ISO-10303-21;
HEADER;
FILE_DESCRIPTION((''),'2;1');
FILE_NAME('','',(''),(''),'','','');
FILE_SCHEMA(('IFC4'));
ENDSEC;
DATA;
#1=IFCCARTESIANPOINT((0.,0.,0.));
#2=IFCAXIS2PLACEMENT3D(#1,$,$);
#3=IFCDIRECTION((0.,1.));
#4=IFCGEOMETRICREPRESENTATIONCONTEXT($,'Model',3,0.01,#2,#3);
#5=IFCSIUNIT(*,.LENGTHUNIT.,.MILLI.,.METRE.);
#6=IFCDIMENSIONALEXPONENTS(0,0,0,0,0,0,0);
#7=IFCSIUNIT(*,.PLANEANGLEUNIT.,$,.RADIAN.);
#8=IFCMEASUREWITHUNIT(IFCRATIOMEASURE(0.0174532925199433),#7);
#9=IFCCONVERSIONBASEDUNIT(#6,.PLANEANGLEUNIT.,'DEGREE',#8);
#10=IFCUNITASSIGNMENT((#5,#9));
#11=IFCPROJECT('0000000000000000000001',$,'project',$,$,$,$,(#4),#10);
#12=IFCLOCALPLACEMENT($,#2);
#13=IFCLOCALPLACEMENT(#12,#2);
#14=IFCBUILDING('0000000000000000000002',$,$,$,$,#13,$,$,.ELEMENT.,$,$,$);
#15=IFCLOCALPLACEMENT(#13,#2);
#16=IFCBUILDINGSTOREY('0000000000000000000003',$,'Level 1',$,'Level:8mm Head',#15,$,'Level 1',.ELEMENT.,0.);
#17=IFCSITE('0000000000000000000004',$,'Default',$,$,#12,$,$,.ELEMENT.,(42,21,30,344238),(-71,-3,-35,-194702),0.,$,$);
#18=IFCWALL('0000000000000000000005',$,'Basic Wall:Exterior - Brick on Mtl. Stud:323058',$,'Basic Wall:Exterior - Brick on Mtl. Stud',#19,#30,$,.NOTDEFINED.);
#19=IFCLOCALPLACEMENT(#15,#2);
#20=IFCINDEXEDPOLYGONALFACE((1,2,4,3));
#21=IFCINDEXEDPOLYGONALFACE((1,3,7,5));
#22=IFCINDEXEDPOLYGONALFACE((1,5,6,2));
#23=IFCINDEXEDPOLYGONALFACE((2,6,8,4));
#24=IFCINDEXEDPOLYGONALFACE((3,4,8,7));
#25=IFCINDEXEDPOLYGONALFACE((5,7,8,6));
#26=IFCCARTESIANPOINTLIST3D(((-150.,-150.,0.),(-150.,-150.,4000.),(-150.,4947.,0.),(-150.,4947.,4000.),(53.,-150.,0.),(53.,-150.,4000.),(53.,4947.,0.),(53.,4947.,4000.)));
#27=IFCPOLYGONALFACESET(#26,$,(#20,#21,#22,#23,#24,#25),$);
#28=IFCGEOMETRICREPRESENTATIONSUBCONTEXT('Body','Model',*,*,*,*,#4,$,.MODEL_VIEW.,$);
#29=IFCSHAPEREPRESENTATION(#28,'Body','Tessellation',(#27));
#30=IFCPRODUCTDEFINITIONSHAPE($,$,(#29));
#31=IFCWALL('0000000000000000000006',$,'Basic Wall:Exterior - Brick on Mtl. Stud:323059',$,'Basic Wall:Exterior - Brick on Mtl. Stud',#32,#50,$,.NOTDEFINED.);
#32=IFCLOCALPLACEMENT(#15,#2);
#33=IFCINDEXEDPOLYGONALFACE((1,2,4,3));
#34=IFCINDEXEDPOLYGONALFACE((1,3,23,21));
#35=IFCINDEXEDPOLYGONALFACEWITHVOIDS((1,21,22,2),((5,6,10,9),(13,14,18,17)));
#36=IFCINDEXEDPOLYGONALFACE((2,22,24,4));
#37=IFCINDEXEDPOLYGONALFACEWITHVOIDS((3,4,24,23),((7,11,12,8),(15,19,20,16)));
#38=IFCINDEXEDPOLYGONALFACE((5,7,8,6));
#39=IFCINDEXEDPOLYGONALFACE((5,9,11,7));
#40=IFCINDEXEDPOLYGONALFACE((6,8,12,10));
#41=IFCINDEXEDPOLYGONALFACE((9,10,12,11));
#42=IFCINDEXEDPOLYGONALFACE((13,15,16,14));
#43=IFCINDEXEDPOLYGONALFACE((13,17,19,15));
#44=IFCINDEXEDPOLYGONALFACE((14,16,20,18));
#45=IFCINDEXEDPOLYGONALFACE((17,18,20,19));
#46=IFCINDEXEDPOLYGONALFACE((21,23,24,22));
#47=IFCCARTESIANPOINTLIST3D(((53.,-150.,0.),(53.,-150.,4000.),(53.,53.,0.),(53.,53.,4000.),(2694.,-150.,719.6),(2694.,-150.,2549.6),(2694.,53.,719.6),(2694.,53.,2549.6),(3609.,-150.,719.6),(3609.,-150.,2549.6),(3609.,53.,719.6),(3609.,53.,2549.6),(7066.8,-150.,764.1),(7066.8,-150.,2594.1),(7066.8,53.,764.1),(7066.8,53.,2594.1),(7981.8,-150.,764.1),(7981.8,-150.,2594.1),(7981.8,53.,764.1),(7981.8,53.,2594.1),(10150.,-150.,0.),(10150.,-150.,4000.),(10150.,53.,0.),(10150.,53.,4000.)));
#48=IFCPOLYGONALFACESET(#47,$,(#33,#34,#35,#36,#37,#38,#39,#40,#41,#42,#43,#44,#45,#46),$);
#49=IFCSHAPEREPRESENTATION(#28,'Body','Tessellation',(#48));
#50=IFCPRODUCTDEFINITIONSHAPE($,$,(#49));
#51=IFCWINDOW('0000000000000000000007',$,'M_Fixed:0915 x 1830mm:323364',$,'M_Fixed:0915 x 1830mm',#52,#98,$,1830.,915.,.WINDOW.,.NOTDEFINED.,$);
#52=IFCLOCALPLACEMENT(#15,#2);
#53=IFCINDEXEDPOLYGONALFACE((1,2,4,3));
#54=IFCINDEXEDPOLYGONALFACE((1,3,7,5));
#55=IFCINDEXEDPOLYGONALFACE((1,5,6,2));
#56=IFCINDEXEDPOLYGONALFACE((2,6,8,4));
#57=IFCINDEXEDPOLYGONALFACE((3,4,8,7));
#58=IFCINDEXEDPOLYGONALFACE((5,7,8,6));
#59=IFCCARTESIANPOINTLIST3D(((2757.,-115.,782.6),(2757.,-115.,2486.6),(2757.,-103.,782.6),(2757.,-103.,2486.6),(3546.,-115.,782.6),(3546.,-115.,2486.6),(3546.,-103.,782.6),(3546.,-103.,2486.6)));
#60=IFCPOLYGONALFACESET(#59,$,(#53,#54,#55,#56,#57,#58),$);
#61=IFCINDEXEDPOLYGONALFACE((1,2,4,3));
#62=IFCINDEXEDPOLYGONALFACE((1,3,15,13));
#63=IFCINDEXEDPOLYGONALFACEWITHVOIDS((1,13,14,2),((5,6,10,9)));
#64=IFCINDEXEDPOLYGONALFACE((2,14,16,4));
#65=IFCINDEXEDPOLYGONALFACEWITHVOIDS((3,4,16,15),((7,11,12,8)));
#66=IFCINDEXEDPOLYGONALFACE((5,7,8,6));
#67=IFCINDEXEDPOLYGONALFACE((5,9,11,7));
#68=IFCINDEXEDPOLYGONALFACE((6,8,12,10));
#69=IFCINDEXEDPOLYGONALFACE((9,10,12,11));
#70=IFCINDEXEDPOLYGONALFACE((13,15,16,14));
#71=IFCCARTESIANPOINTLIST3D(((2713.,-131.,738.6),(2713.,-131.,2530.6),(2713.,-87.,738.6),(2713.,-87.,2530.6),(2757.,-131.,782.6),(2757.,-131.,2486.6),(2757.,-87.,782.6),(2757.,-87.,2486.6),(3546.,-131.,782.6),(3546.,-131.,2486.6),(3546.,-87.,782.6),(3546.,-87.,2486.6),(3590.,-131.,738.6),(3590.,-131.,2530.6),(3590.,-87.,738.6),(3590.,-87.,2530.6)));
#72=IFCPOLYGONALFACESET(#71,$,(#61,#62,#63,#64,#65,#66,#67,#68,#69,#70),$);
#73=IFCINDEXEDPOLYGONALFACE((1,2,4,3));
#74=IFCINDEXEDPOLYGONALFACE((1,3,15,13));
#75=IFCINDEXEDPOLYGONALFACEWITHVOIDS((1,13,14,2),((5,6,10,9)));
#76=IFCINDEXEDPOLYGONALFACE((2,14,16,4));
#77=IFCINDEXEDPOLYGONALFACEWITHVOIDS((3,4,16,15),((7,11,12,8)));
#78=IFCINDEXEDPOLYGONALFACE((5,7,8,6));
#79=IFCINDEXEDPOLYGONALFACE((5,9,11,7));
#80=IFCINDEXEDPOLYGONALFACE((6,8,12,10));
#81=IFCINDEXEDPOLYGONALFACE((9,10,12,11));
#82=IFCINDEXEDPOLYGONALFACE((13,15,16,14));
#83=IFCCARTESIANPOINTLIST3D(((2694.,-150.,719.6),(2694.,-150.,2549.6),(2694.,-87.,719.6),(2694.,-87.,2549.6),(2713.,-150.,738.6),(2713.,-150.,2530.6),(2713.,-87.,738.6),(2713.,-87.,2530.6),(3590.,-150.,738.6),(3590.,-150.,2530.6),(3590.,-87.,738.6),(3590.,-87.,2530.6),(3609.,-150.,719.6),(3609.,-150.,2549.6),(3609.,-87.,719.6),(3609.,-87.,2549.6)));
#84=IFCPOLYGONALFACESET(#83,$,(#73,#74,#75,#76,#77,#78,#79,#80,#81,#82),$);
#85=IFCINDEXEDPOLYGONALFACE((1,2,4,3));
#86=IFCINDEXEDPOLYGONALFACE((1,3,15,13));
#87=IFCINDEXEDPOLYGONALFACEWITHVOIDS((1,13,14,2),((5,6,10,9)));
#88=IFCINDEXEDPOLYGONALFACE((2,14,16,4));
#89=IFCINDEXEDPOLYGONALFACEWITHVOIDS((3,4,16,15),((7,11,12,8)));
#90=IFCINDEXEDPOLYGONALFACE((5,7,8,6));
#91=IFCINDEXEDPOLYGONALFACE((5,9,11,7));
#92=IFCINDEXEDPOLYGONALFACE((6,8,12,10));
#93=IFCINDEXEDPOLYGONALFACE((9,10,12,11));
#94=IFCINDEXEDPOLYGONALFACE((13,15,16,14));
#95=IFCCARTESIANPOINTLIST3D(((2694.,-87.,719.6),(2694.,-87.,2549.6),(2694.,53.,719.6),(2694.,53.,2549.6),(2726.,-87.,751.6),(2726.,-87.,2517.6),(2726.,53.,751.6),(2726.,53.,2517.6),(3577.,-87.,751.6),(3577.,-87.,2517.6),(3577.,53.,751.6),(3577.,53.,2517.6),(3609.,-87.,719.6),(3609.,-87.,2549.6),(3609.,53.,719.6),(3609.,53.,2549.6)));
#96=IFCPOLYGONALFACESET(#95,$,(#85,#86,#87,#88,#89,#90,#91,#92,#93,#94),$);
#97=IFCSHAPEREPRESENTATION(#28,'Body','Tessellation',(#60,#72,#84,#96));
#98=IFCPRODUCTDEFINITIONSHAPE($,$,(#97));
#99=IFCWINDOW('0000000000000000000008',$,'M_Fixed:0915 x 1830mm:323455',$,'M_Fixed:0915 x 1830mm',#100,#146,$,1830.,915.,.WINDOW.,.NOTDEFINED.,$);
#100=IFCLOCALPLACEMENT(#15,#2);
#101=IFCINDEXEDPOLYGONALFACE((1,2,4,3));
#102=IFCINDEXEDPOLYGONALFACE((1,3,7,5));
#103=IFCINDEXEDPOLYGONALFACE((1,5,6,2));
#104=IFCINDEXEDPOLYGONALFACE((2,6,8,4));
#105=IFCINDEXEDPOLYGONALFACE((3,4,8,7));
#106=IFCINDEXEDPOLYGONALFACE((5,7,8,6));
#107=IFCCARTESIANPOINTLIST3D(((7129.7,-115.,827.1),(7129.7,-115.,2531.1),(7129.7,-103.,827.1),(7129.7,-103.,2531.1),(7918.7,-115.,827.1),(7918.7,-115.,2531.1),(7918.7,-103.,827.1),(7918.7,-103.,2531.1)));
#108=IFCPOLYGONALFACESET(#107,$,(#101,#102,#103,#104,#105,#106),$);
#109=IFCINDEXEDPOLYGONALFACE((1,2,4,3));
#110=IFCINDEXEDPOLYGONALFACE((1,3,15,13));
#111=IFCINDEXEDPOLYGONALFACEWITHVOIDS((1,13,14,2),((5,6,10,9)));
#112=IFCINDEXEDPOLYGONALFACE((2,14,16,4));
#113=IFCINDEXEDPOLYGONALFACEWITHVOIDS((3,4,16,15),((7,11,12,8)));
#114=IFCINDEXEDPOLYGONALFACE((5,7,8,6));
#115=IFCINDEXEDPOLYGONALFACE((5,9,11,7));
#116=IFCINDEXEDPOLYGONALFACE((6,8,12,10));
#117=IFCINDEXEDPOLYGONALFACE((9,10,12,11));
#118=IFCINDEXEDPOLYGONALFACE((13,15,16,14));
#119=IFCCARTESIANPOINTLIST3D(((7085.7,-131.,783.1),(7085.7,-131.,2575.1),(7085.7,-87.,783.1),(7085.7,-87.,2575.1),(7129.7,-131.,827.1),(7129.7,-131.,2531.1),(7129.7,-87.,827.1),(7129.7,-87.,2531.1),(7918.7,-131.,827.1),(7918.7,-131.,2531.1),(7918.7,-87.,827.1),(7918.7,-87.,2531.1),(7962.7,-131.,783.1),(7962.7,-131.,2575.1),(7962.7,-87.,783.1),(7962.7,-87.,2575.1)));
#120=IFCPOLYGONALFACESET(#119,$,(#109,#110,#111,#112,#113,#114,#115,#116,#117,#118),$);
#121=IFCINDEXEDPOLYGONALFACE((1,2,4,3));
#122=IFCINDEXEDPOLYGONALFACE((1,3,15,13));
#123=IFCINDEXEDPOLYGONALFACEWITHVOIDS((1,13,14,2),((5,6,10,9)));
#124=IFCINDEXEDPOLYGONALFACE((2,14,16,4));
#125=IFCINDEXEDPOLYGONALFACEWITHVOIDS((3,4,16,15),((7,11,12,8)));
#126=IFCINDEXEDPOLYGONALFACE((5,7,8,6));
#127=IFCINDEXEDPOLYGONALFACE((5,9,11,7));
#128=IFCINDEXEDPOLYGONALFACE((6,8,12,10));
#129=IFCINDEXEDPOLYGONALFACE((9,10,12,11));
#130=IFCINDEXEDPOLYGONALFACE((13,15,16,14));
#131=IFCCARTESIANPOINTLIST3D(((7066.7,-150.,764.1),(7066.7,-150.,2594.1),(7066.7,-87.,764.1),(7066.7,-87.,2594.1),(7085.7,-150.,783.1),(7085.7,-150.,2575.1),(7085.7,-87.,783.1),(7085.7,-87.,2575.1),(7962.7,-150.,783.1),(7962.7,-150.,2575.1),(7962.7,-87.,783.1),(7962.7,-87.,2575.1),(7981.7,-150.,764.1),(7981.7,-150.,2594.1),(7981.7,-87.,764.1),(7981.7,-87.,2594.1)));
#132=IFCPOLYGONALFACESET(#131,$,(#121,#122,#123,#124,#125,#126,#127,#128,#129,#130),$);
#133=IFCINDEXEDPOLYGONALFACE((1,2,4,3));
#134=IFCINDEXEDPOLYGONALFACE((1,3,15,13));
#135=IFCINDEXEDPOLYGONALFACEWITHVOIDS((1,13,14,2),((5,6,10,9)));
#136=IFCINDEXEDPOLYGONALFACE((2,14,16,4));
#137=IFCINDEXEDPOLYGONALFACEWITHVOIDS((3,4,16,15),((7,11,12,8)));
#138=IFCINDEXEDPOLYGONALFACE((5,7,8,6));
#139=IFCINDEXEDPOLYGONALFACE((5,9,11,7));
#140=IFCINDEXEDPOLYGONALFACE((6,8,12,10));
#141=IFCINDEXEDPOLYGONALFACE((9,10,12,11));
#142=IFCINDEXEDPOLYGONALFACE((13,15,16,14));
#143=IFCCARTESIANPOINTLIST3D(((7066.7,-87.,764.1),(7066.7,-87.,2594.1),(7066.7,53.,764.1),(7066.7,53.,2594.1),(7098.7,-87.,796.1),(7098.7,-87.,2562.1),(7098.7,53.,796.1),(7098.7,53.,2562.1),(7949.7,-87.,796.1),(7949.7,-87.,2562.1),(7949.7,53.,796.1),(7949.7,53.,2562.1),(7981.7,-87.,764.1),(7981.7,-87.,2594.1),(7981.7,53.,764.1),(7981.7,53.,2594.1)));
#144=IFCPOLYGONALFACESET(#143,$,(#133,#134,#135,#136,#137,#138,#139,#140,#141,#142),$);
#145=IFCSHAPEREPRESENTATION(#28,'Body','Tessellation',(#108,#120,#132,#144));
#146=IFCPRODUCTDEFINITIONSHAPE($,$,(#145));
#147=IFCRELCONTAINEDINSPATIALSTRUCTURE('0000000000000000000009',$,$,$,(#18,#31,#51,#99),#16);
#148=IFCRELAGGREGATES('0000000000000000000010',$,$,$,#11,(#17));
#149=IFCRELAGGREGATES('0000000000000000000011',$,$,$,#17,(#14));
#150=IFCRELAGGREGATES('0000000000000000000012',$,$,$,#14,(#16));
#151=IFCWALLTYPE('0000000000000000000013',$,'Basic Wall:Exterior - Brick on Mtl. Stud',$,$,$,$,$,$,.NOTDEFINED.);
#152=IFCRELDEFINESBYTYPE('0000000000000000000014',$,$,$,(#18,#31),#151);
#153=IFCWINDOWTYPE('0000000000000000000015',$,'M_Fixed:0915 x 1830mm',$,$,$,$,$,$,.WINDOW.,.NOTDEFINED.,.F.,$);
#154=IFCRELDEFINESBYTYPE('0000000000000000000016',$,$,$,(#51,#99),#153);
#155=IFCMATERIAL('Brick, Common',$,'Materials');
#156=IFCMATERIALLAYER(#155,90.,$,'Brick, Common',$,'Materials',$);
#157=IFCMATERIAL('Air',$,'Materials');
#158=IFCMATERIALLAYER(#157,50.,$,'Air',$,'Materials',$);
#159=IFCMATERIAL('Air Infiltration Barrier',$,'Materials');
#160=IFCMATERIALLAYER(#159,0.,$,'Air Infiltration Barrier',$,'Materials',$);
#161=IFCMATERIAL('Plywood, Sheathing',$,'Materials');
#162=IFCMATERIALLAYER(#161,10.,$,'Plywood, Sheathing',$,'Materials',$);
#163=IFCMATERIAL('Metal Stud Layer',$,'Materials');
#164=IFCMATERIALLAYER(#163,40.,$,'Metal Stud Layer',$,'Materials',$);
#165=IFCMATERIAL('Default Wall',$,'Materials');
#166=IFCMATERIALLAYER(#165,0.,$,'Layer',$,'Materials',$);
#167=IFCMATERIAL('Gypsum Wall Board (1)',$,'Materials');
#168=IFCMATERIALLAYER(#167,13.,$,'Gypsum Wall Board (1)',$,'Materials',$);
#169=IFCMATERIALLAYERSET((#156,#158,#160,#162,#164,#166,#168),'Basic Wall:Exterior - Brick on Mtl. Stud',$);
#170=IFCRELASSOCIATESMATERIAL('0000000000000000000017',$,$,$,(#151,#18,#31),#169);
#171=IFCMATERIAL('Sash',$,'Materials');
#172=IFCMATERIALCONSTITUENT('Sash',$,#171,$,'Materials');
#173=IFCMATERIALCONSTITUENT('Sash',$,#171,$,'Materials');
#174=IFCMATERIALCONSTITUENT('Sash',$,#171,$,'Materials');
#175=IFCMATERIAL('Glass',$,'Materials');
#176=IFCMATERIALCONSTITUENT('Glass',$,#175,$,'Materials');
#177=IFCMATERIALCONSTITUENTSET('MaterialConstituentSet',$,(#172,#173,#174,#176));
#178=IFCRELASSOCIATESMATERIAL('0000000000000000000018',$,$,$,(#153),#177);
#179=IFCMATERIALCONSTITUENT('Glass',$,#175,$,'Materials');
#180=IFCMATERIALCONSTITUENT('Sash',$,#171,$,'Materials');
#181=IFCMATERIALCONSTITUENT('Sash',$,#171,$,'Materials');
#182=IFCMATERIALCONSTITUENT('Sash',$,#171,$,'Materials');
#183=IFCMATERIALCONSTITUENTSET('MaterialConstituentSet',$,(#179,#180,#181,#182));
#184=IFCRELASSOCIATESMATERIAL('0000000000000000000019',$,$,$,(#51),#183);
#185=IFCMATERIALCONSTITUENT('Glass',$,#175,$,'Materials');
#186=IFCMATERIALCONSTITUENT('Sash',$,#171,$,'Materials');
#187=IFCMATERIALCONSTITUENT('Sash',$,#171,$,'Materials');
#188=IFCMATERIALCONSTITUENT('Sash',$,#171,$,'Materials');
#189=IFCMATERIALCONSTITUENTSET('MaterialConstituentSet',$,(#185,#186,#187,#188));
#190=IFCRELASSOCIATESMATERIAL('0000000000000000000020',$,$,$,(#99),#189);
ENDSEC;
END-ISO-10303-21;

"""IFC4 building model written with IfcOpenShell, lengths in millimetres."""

from ifc_helpers import new_model, entity, si_unit, converted_unit, direction, frame, frame_2d, origin, place, context, subcontext, project, spatial, polyline, rectangle, outline, extrude, source, transform, mapped, material, layer, layer_set, layer_usage, constituent, constituent_set, type_object, type_shapes, element, fill, save


model = new_model("IFC4")

# Units and contexts
model_context = context("Model", 3, precision=0.01, world=origin(), true_north=direction((0.0, 1.0)))
body_context = subcontext(model_context, "Body", "Model", "MODEL_VIEW")
ifc_project = project(units=[si_unit("LENGTHUNIT", "METRE", prefix="MILLI"), converted_unit("PLANEANGLEUNIT", "DEGREE", entity("IfcRatioMeasure", 0.0174532925199433), si_unit("PLANEANGLEUNIT", "RADIAN"), dimensions=[0, 0, 0, 0, 0, 0, 0])], contexts=[model_context])

# Site, building, storey
site_placement = place(None, origin())
site = spatial("IfcSite", under=ifc_project, at=site_placement, Name="Default", CompositionType="ELEMENT", RefLatitude=(42, 21, 30, 344238), RefLongitude=(-71, -3, -35, -194702), RefElevation=0.0)
building_placement = place(site_placement, origin())
building = spatial("IfcBuilding", under=site, at=building_placement, CompositionType="ELEMENT")
storey_placement = place(building_placement, origin())
storey = spatial("IfcBuildingStorey", under=building, at=storey_placement, Name="Level 1", ObjectType="Level:8mm Head", LongName="Level 1", CompositionType="ELEMENT", Elevation=0.0)

# Shared definitions
ifc_material_1 = material(Name="Brick, Common", Category="Materials")
ifc_layer_1 = layer(ifc_material_1, 90.0, Name="Brick, Common", Category="Materials")
ifc_material_2 = material(Name="Air", Category="Materials")
ifc_layer_2 = layer(ifc_material_2, 50.0, Name="Air", Category="Materials")
ifc_material_3 = material(Name="Air Infiltration Barrier", Category="Materials")
ifc_layer_3 = layer(ifc_material_3, 0.0, Name="Air Infiltration Barrier", Category="Materials")
ifc_material_4 = material(Name="Plywood, Sheathing", Category="Materials")
ifc_layer_4 = layer(ifc_material_4, 10.0, Name="Plywood, Sheathing", Category="Materials")
ifc_material_5 = material(Name="Metal Stud Layer", Category="Materials")
ifc_layer_5 = layer(ifc_material_5, 40.0, Name="Metal Stud Layer", Category="Materials")
ifc_material_6 = material(Name="Default Wall", Category="Materials")
ifc_layer_6 = layer(ifc_material_6, 0.0, Name="Layer", Category="Materials")
ifc_material_7 = material(Name="Gypsum Wall Board (1)", Category="Materials")
ifc_layer_7 = layer(ifc_material_7, 13.0, Name="Gypsum Wall Board (1)", Category="Materials")
ifc_layer_set_1 = layer_set([ifc_layer_1, ifc_layer_2, ifc_layer_3, ifc_layer_4, ifc_layer_5, ifc_layer_6, ifc_layer_7], Name="Basic Wall:Exterior - Brick on Mtl. Stud")
wall_type_1 = type_object("IfcWallType", Name="Basic Wall:Exterior - Brick on Mtl. Stud", PredefinedType="NOTDEFINED", material=ifc_layer_set_1)
ifc_material_8 = material(Name="Glass", Category="Materials")
ifc_material_9 = material(Name="Sash", Category="Materials")
ifc_constituent_1 = constituent(ifc_material_9, Name="Sash", Category="Materials")
ifc_constituent_2 = constituent(ifc_material_9, Name="Sash", Category="Materials")
ifc_constituent_3 = constituent(ifc_material_9, Name="Sash", Category="Materials")
ifc_constituent_4 = constituent(ifc_material_8, Name="Glass", Category="Materials")
ifc_constituent_set_1 = constituent_set(constituents=[ifc_constituent_1, ifc_constituent_2, ifc_constituent_3, ifc_constituent_4], Name="MaterialConstituentSet")
window_type = type_object("IfcWindowType", Name="M_Fixed:0915 x 1830mm", ParameterTakesPrecedence=False, PartitioningType="NOTDEFINED", PredefinedType="WINDOW", material=ifc_constituent_set_1)
shared_shape_1 = source(origin(), body_context, "Body", "SweptSolid", [
    extrude(rectangle(XDim=12.0, YDim=789.0, at=frame_2d((0.0, 0.0), x_axis=(1.0, 0.0))), frame((457.5, 162.0, 63.0), z_axis=(0.0, 0.0, 1.0), x_axis=(0.0, -1.0, 0.0)), (0.0, 0.0, 1.0), 1704.0),
    extrude(outline(polyline([(-438.5, -896.0), (438.5, -896.0), (438.5, 896.0), (-438.5, 896.0), (-438.5, -896.0)]), holes=[polyline([(-394.5, -852.0), (-394.5, 852.0), (394.5, 852.0), (394.5, -852.0), (-394.5, -852.0)])]), frame((457.5, 140.0, 915.0), z_axis=(0.0, 1.0, 0.0), x_axis=(1.0, 0.0, 0.0)), (0.0, 0.0, 1.0), 44.0),
    extrude(outline(polyline([(-457.5, -915.0), (457.5, -915.0), (457.5, 915.0), (-457.5, 915.0), (-457.5, -915.0)]), holes=[polyline([(-438.5, -896.0), (-438.5, 896.0), (438.5, 896.0), (438.5, -896.0), (-438.5, -896.0)])]), frame((457.5, 140.0, 915.0), z_axis=(0.0, 1.0, 0.0), x_axis=(1.0, 0.0, 0.0)), (0.0, 0.0, 1.0), 63.0),
    extrude(outline(polyline([(-457.5, -915.0), (457.5, -915.0), (457.5, 915.0), (-457.5, 915.0), (-457.5, -915.0)]), holes=[polyline([(-425.5, -883.0), (-425.5, 883.0), (425.5, 883.0), (425.5, -883.0), (-425.5, -883.0)])]), frame((457.5, 0.0, 915.0), z_axis=(0.0, 1.0, 0.0), x_axis=(1.0, 0.0, 0.0)), (0.0, 0.0, 1.0), 140.0),
])
type_shapes(window_type, [shared_shape_1])

# Wall
ifc_layer_usage_1 = layer_usage(ifc_layer_set_1, "AXIS2", "NEGATIVE", 101.5)
wall_1_placement = place(storey_placement, frame((-48.5, -150.0, 0.0), z_axis=(0.0, 0.0, 1.0), x_axis=(0.0, 1.0, 0.0)))
element("IfcWall", 1, at=wall_1_placement, inside=storey, type_object=wall_type_1, material=ifc_layer_usage_1, Name="Basic Wall:Exterior - Brick on Mtl. Stud:323058", ObjectType="Basic Wall:Exterior - Brick on Mtl. Stud", PredefinedType="NOTDEFINED", context=body_context, shape_type="SweptSolid", body=[
    extrude(rectangle(XDim=5097.0, YDim=203.0, at=frame_2d((2548.5, 0.0), x_axis=(-1.0, 0.0))), origin(), (0.0, 0.0, 1.0), 4000.0),
])

# Wall, openings, windows
ifc_layer_usage_2 = layer_usage(ifc_layer_set_1, "AXIS2", "NEGATIVE", 101.5)
wall_2_placement = place(storey_placement, frame((10150.0, -48.5, 0.0), z_axis=(0.0, 0.0, 1.0), x_axis=(-1.0, 0.0, 0.0)))
wall_2 = element("IfcWall", 2, at=wall_2_placement, inside=storey, type_object=wall_type_1, material=ifc_layer_usage_2, Name="Basic Wall:Exterior - Brick on Mtl. Stud:323059", ObjectType="Basic Wall:Exterior - Brick on Mtl. Stud", PredefinedType="NOTDEFINED", context=body_context, shape_type="SweptSolid", body=[
    extrude(rectangle(XDim=10097.0, YDim=203.0, at=frame_2d((5048.5, 0.0), x_axis=(-1.0, 0.0))), origin(), (0.0, 0.0, 1.0), 4000.0),
])
opening_1_placement = place(wall_2_placement, frame((6541.0, -101.5, 719.6)))
opening_1 = element("IfcOpeningElement", 3, at=opening_1_placement, cuts=wall_2, ObjectType="Opening", PredefinedType="OPENING", context=body_context, shape_type="SweptSolid", body=[
    extrude(rectangle(XDim=1830.0, YDim=915.0, at=frame_2d((915.0, 457.5), x_axis=(1.0, 0.0))), frame((0.0, 0.0, 0.0), z_axis=(0.0, 1.0, 0.0), x_axis=(0.0, 0.0, 1.0)), (0.0, 0.0, 1.0), 203.0),
])
opening_2_placement = place(wall_2_placement, frame((2168.2, -101.5, 764.1)))
opening_2 = element("IfcOpeningElement", 4, at=opening_2_placement, cuts=wall_2, ObjectType="Opening", PredefinedType="OPENING", context=body_context, shape_type="SweptSolid", body=[
    extrude(rectangle(XDim=1830.0, YDim=915.0, at=frame_2d((915.0, 457.5), x_axis=(1.0, 0.0))), frame((0.0, 0.0, 0.0), z_axis=(0.0, 1.0, 0.0), x_axis=(0.0, 0.0, 1.0)), (0.0, 0.0, 1.0), 203.0),
])
ifc_constituent_5 = constituent(ifc_material_8, Name="Glass", Category="Materials")
ifc_constituent_6 = constituent(ifc_material_9, Name="Sash", Category="Materials")
ifc_constituent_7 = constituent(ifc_material_9, Name="Sash", Category="Materials")
ifc_constituent_8 = constituent(ifc_material_9, Name="Sash", Category="Materials")
ifc_constituent_set_2 = constituent_set(constituents=[ifc_constituent_5, ifc_constituent_6, ifc_constituent_7, ifc_constituent_8], Name="MaterialConstituentSet")
window_1_placement = place(opening_1_placement, origin())
window_1 = element("IfcWindow", 5, at=window_1_placement, inside=storey, type_object=window_type, material=ifc_constituent_set_2, Name="M_Fixed:0915 x 1830mm:323364", ObjectType="M_Fixed:0915 x 1830mm", OverallHeight=1830.0, OverallWidth=915.0, PartitioningType="NOTDEFINED", PredefinedType="WINDOW", context=body_context, shape_type="MappedRepresentation", body=[
    mapped(shared_shape_1, transform((0.0, 0.0, 0.0), scale=1.0)),
])
fill(opening_1, window_1)
ifc_constituent_9 = constituent(ifc_material_8, Name="Glass", Category="Materials")
ifc_constituent_10 = constituent(ifc_material_9, Name="Sash", Category="Materials")
ifc_constituent_11 = constituent(ifc_material_9, Name="Sash", Category="Materials")
ifc_constituent_12 = constituent(ifc_material_9, Name="Sash", Category="Materials")
ifc_constituent_set_3 = constituent_set(constituents=[ifc_constituent_9, ifc_constituent_10, ifc_constituent_11, ifc_constituent_12], Name="MaterialConstituentSet")
window_2_placement = place(opening_2_placement, origin())
window_2 = element("IfcWindow", 6, at=window_2_placement, inside=storey, type_object=window_type, material=ifc_constituent_set_3, Name="M_Fixed:0915 x 1830mm:323455", ObjectType="M_Fixed:0915 x 1830mm", OverallHeight=1830.0, OverallWidth=915.0, PartitioningType="NOTDEFINED", PredefinedType="WINDOW", context=body_context, shape_type="MappedRepresentation", body=[
    mapped(shared_shape_1, transform((0.0, 0.0, 0.0), scale=1.0)),
])
fill(opening_2, window_2)

save(model, "model.ifc")
